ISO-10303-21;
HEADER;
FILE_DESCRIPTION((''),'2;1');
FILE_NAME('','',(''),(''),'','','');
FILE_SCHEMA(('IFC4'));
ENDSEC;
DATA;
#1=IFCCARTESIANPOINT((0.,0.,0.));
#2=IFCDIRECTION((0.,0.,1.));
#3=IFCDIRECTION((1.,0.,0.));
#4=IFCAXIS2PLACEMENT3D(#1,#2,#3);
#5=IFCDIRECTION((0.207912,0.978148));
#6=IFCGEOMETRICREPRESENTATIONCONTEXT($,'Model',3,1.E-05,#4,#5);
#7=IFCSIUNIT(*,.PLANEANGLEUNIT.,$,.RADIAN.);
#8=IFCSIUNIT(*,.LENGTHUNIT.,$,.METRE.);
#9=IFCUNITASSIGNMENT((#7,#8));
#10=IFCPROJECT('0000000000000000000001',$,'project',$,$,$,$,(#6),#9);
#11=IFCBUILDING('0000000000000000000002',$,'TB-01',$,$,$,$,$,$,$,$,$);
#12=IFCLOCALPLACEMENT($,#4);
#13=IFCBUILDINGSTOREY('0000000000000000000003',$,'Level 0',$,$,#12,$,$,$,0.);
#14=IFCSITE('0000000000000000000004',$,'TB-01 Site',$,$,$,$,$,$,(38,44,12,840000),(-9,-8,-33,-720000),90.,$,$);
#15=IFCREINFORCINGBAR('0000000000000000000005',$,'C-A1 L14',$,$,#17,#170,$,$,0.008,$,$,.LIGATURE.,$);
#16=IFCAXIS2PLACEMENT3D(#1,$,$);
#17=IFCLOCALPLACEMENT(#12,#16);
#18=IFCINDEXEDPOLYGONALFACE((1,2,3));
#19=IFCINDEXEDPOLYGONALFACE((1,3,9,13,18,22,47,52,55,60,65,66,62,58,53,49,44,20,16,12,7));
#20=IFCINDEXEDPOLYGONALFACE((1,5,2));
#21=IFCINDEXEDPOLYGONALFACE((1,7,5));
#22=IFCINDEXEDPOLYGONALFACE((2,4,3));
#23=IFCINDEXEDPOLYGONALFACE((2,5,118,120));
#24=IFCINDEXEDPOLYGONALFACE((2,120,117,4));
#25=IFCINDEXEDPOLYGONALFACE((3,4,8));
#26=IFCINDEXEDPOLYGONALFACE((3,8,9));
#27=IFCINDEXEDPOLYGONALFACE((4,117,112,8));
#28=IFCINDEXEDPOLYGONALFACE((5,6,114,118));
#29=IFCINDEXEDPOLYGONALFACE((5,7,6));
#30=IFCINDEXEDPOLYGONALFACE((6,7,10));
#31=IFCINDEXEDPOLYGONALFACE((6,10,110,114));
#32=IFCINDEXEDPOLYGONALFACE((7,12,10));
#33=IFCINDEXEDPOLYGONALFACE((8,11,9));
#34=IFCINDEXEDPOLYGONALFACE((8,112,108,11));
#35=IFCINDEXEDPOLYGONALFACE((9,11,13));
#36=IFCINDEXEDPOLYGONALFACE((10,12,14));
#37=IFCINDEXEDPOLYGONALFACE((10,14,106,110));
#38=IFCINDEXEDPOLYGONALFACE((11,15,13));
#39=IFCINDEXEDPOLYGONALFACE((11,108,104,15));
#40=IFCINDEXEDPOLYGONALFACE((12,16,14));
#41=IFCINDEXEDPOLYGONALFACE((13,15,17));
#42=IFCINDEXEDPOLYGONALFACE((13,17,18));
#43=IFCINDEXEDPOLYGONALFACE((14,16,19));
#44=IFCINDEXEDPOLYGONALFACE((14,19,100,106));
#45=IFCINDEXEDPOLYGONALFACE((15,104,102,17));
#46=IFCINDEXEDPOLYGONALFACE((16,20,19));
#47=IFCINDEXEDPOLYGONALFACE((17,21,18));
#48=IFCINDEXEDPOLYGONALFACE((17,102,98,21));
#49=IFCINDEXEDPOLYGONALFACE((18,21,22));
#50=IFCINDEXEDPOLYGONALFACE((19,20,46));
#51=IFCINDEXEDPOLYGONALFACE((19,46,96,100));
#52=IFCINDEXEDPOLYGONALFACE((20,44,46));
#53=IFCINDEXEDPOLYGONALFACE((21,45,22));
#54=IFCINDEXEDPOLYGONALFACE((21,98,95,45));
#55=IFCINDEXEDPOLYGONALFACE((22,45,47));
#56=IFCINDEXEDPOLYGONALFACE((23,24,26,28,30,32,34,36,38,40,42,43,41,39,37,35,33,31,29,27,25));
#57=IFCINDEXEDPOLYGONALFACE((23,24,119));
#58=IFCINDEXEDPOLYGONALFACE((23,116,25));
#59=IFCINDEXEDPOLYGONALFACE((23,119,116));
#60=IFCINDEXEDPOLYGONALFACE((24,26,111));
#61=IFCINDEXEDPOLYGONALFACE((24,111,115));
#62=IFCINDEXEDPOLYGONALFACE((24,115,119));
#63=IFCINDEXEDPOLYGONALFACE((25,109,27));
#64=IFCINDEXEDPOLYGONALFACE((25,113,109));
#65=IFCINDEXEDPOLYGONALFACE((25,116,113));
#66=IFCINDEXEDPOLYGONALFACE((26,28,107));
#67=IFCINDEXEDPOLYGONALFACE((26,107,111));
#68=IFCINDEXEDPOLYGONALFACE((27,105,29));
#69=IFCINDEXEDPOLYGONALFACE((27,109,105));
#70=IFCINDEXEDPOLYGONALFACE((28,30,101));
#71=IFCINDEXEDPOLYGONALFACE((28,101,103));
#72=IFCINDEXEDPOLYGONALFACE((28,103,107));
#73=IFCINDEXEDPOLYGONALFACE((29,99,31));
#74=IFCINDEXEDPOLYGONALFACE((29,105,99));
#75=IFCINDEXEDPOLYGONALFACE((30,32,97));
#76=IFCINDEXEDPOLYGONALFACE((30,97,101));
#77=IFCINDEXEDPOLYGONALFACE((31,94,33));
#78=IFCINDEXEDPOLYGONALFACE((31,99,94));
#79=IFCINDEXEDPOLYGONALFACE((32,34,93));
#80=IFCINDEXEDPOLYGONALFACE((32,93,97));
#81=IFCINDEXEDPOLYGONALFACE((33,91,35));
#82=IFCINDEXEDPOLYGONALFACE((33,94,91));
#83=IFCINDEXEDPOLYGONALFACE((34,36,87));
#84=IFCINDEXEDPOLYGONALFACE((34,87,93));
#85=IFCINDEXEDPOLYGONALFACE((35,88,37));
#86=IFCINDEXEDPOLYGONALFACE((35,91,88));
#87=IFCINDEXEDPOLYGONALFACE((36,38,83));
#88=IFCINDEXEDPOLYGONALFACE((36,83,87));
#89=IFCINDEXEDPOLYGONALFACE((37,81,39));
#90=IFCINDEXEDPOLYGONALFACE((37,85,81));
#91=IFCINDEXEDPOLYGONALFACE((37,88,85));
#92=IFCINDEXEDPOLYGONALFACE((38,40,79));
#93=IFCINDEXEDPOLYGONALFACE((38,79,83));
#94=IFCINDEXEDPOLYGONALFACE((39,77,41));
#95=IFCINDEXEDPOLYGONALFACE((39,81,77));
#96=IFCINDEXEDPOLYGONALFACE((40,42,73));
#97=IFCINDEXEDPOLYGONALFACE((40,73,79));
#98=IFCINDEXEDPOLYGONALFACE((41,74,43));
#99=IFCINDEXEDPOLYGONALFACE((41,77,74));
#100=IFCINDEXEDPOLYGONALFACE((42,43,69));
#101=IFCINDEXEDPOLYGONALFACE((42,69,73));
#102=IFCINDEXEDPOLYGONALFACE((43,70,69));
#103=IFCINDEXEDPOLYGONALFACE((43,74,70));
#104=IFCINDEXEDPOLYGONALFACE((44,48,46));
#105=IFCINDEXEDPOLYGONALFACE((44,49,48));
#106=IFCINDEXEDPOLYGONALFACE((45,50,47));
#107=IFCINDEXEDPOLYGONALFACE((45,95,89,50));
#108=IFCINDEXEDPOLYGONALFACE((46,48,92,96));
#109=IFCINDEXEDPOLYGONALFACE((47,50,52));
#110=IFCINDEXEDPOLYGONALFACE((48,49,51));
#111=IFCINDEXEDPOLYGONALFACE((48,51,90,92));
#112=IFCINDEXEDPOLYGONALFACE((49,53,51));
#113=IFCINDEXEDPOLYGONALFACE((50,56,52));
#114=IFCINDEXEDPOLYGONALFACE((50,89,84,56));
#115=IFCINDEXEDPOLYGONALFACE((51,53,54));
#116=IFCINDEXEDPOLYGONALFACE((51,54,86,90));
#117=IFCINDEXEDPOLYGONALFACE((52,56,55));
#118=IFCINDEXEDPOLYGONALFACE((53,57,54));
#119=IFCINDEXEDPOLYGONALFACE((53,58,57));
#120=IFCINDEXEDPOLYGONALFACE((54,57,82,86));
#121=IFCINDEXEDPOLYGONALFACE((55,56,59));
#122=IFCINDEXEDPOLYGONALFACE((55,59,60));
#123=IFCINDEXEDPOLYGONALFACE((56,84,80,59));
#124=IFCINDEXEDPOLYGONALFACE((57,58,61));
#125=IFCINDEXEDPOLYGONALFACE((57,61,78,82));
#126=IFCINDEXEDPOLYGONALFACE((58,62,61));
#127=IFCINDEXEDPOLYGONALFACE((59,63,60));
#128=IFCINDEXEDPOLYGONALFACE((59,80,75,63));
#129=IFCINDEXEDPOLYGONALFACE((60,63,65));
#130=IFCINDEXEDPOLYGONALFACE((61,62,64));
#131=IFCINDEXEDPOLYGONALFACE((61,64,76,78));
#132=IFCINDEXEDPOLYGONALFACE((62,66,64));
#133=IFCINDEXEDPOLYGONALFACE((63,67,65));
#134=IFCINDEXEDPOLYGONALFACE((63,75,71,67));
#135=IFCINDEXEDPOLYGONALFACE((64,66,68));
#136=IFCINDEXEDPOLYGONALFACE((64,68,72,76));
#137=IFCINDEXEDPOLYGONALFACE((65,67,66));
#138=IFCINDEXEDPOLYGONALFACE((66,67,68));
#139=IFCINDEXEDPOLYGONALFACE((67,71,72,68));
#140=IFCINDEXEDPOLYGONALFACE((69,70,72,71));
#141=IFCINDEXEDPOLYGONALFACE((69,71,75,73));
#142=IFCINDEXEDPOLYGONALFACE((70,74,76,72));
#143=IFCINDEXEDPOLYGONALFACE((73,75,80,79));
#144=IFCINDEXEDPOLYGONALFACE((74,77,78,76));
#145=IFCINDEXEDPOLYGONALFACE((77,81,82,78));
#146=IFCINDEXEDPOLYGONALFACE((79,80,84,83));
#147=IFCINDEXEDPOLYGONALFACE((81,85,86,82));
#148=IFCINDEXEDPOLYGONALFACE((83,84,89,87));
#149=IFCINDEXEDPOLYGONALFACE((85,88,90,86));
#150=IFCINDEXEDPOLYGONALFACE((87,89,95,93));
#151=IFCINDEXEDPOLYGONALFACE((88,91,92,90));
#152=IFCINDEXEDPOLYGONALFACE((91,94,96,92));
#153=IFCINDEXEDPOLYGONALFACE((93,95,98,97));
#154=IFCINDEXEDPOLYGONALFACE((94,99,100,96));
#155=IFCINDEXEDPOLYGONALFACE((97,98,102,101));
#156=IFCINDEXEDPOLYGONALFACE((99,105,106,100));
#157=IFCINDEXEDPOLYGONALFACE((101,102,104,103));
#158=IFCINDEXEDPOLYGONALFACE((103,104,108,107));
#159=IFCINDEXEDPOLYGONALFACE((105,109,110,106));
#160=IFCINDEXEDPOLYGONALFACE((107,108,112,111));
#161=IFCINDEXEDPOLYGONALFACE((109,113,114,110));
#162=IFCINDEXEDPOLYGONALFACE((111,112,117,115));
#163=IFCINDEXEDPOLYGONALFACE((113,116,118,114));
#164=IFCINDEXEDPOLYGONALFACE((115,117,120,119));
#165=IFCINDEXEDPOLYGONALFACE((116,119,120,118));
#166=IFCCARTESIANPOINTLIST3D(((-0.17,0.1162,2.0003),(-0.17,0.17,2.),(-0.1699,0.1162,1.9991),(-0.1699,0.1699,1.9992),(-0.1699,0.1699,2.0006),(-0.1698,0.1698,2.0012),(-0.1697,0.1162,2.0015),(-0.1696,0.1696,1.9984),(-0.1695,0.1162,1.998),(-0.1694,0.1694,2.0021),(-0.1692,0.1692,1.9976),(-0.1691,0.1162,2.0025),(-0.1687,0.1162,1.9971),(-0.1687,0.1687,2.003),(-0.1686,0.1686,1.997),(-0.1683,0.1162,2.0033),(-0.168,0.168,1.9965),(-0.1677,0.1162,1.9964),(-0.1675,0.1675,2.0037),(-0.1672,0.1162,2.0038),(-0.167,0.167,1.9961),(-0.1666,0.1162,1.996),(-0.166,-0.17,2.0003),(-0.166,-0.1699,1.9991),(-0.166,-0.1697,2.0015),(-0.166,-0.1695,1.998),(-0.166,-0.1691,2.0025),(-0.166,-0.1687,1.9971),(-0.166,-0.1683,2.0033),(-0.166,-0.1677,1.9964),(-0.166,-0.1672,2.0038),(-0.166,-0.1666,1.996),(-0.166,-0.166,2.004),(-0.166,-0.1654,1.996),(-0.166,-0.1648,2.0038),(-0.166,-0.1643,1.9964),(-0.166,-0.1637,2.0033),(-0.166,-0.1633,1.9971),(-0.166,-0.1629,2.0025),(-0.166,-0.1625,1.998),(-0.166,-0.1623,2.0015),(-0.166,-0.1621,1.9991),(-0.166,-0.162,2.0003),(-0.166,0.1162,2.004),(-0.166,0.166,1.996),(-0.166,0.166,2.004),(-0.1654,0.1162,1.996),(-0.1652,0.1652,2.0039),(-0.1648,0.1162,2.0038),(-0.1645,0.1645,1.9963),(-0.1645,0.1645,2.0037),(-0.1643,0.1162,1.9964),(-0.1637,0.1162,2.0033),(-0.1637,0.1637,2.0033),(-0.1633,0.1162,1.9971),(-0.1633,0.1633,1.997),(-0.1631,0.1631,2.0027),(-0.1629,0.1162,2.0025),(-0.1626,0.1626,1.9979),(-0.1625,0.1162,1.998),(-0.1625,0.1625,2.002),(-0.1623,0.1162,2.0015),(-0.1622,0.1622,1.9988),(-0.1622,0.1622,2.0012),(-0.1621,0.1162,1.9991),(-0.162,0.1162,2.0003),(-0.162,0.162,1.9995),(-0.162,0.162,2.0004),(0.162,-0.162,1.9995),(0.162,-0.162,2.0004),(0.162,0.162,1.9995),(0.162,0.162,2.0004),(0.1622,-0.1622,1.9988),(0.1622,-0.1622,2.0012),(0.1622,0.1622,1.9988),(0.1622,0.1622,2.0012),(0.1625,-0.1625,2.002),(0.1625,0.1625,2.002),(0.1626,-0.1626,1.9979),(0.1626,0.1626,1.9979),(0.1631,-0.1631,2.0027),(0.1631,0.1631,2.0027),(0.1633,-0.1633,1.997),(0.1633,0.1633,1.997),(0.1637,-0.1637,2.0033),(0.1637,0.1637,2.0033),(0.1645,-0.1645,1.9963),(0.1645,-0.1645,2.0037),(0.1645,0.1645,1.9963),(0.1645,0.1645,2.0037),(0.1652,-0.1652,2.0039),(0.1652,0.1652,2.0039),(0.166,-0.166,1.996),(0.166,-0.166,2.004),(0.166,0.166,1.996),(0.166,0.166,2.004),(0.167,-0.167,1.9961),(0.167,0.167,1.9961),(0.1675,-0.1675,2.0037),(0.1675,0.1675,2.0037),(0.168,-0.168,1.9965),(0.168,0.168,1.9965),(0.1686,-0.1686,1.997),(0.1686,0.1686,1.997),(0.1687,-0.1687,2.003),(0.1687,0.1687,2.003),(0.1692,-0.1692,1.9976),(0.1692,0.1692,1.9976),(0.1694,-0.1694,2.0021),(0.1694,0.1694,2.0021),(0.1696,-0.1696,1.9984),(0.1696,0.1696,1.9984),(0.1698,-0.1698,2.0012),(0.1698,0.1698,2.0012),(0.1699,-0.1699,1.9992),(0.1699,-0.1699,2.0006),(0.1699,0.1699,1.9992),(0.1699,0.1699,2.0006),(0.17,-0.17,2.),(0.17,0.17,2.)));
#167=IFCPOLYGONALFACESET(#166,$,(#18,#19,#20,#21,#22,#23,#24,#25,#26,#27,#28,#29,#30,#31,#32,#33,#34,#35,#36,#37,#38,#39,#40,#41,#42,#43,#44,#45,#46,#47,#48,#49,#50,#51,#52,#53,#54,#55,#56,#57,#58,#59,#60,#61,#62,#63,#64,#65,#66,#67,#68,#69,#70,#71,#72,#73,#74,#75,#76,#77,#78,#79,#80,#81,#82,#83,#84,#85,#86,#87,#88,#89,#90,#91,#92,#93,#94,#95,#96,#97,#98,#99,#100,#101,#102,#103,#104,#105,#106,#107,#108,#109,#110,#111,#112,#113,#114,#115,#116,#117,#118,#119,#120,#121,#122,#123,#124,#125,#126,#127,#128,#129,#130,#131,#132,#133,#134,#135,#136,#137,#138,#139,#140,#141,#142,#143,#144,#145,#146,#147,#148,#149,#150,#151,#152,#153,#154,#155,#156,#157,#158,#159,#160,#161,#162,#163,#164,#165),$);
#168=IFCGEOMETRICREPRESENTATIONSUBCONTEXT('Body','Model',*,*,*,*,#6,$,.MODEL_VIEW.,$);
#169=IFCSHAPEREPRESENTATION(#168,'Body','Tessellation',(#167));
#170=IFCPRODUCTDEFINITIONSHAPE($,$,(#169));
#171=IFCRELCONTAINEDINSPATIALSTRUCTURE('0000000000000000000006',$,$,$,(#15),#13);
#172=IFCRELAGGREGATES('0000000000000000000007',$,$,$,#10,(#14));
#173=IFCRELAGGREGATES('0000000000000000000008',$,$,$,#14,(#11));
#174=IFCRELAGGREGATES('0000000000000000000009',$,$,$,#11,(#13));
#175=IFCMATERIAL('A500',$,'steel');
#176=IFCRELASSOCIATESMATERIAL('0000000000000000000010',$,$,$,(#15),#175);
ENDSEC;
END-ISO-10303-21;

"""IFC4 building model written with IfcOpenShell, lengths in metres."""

from ifc_helpers import new_model, entity, si_unit, direction, origin_with_axes, place, context, subcontext, project, spatial, material, element, save


model = new_model("IFC4")

# Units and contexts
model_context = context("Model", 3, precision=1e-05, world=origin_with_axes(), true_north=direction((0.207912, 0.978148)))
body_context = subcontext(model_context, "Body", "Model", "MODEL_VIEW")
ifc_project = project(units=[si_unit("PLANEANGLEUNIT", "RADIAN"), si_unit("LENGTHUNIT", "METRE")], contexts=[model_context])

# Site, building, storey
site = spatial("IfcSite", under=ifc_project, Name="TB-01 Site", RefLatitude=(38, 44, 12, 840000), RefLongitude=(-9, -8, -33, -720000), RefElevation=90.0)
building = spatial("IfcBuilding", under=site, Name="TB-01")
storey_placement = place(None, origin_with_axes())
storey = spatial("IfcBuildingStorey", under=building, at=storey_placement, Name="Level 0", Elevation=0.0)

# Reinforcing bar
ifc_material_1 = material(Name="A500", Category="steel")
reinforcing_bar_1_placement = place(storey_placement, origin_with_axes())
element("IfcReinforcingBar", 1, at=reinforcing_bar_1_placement, inside=storey, material=ifc_material_1, Name="C-A1 L14", NominalDiameter=0.008, PredefinedType="LIGATURE", context=body_context, shape_type="AdvancedSweptSolid", body=[
    entity("IfcSweptDiskSolid", entity("IfcPolyline", [entity("IfcCartesianPoint", [-0.166, -0.166, 2.0]), entity("IfcCartesianPoint", [0.166, -0.166, 2.0]), entity("IfcCartesianPoint", [0.166, 0.166, 2.0]), entity("IfcCartesianPoint", [-0.166, 0.166, 2.0]), entity("IfcCartesianPoint", [-0.166, 0.1162, 2.0])]), 0.004),
])

save(model, "model.ifc")
